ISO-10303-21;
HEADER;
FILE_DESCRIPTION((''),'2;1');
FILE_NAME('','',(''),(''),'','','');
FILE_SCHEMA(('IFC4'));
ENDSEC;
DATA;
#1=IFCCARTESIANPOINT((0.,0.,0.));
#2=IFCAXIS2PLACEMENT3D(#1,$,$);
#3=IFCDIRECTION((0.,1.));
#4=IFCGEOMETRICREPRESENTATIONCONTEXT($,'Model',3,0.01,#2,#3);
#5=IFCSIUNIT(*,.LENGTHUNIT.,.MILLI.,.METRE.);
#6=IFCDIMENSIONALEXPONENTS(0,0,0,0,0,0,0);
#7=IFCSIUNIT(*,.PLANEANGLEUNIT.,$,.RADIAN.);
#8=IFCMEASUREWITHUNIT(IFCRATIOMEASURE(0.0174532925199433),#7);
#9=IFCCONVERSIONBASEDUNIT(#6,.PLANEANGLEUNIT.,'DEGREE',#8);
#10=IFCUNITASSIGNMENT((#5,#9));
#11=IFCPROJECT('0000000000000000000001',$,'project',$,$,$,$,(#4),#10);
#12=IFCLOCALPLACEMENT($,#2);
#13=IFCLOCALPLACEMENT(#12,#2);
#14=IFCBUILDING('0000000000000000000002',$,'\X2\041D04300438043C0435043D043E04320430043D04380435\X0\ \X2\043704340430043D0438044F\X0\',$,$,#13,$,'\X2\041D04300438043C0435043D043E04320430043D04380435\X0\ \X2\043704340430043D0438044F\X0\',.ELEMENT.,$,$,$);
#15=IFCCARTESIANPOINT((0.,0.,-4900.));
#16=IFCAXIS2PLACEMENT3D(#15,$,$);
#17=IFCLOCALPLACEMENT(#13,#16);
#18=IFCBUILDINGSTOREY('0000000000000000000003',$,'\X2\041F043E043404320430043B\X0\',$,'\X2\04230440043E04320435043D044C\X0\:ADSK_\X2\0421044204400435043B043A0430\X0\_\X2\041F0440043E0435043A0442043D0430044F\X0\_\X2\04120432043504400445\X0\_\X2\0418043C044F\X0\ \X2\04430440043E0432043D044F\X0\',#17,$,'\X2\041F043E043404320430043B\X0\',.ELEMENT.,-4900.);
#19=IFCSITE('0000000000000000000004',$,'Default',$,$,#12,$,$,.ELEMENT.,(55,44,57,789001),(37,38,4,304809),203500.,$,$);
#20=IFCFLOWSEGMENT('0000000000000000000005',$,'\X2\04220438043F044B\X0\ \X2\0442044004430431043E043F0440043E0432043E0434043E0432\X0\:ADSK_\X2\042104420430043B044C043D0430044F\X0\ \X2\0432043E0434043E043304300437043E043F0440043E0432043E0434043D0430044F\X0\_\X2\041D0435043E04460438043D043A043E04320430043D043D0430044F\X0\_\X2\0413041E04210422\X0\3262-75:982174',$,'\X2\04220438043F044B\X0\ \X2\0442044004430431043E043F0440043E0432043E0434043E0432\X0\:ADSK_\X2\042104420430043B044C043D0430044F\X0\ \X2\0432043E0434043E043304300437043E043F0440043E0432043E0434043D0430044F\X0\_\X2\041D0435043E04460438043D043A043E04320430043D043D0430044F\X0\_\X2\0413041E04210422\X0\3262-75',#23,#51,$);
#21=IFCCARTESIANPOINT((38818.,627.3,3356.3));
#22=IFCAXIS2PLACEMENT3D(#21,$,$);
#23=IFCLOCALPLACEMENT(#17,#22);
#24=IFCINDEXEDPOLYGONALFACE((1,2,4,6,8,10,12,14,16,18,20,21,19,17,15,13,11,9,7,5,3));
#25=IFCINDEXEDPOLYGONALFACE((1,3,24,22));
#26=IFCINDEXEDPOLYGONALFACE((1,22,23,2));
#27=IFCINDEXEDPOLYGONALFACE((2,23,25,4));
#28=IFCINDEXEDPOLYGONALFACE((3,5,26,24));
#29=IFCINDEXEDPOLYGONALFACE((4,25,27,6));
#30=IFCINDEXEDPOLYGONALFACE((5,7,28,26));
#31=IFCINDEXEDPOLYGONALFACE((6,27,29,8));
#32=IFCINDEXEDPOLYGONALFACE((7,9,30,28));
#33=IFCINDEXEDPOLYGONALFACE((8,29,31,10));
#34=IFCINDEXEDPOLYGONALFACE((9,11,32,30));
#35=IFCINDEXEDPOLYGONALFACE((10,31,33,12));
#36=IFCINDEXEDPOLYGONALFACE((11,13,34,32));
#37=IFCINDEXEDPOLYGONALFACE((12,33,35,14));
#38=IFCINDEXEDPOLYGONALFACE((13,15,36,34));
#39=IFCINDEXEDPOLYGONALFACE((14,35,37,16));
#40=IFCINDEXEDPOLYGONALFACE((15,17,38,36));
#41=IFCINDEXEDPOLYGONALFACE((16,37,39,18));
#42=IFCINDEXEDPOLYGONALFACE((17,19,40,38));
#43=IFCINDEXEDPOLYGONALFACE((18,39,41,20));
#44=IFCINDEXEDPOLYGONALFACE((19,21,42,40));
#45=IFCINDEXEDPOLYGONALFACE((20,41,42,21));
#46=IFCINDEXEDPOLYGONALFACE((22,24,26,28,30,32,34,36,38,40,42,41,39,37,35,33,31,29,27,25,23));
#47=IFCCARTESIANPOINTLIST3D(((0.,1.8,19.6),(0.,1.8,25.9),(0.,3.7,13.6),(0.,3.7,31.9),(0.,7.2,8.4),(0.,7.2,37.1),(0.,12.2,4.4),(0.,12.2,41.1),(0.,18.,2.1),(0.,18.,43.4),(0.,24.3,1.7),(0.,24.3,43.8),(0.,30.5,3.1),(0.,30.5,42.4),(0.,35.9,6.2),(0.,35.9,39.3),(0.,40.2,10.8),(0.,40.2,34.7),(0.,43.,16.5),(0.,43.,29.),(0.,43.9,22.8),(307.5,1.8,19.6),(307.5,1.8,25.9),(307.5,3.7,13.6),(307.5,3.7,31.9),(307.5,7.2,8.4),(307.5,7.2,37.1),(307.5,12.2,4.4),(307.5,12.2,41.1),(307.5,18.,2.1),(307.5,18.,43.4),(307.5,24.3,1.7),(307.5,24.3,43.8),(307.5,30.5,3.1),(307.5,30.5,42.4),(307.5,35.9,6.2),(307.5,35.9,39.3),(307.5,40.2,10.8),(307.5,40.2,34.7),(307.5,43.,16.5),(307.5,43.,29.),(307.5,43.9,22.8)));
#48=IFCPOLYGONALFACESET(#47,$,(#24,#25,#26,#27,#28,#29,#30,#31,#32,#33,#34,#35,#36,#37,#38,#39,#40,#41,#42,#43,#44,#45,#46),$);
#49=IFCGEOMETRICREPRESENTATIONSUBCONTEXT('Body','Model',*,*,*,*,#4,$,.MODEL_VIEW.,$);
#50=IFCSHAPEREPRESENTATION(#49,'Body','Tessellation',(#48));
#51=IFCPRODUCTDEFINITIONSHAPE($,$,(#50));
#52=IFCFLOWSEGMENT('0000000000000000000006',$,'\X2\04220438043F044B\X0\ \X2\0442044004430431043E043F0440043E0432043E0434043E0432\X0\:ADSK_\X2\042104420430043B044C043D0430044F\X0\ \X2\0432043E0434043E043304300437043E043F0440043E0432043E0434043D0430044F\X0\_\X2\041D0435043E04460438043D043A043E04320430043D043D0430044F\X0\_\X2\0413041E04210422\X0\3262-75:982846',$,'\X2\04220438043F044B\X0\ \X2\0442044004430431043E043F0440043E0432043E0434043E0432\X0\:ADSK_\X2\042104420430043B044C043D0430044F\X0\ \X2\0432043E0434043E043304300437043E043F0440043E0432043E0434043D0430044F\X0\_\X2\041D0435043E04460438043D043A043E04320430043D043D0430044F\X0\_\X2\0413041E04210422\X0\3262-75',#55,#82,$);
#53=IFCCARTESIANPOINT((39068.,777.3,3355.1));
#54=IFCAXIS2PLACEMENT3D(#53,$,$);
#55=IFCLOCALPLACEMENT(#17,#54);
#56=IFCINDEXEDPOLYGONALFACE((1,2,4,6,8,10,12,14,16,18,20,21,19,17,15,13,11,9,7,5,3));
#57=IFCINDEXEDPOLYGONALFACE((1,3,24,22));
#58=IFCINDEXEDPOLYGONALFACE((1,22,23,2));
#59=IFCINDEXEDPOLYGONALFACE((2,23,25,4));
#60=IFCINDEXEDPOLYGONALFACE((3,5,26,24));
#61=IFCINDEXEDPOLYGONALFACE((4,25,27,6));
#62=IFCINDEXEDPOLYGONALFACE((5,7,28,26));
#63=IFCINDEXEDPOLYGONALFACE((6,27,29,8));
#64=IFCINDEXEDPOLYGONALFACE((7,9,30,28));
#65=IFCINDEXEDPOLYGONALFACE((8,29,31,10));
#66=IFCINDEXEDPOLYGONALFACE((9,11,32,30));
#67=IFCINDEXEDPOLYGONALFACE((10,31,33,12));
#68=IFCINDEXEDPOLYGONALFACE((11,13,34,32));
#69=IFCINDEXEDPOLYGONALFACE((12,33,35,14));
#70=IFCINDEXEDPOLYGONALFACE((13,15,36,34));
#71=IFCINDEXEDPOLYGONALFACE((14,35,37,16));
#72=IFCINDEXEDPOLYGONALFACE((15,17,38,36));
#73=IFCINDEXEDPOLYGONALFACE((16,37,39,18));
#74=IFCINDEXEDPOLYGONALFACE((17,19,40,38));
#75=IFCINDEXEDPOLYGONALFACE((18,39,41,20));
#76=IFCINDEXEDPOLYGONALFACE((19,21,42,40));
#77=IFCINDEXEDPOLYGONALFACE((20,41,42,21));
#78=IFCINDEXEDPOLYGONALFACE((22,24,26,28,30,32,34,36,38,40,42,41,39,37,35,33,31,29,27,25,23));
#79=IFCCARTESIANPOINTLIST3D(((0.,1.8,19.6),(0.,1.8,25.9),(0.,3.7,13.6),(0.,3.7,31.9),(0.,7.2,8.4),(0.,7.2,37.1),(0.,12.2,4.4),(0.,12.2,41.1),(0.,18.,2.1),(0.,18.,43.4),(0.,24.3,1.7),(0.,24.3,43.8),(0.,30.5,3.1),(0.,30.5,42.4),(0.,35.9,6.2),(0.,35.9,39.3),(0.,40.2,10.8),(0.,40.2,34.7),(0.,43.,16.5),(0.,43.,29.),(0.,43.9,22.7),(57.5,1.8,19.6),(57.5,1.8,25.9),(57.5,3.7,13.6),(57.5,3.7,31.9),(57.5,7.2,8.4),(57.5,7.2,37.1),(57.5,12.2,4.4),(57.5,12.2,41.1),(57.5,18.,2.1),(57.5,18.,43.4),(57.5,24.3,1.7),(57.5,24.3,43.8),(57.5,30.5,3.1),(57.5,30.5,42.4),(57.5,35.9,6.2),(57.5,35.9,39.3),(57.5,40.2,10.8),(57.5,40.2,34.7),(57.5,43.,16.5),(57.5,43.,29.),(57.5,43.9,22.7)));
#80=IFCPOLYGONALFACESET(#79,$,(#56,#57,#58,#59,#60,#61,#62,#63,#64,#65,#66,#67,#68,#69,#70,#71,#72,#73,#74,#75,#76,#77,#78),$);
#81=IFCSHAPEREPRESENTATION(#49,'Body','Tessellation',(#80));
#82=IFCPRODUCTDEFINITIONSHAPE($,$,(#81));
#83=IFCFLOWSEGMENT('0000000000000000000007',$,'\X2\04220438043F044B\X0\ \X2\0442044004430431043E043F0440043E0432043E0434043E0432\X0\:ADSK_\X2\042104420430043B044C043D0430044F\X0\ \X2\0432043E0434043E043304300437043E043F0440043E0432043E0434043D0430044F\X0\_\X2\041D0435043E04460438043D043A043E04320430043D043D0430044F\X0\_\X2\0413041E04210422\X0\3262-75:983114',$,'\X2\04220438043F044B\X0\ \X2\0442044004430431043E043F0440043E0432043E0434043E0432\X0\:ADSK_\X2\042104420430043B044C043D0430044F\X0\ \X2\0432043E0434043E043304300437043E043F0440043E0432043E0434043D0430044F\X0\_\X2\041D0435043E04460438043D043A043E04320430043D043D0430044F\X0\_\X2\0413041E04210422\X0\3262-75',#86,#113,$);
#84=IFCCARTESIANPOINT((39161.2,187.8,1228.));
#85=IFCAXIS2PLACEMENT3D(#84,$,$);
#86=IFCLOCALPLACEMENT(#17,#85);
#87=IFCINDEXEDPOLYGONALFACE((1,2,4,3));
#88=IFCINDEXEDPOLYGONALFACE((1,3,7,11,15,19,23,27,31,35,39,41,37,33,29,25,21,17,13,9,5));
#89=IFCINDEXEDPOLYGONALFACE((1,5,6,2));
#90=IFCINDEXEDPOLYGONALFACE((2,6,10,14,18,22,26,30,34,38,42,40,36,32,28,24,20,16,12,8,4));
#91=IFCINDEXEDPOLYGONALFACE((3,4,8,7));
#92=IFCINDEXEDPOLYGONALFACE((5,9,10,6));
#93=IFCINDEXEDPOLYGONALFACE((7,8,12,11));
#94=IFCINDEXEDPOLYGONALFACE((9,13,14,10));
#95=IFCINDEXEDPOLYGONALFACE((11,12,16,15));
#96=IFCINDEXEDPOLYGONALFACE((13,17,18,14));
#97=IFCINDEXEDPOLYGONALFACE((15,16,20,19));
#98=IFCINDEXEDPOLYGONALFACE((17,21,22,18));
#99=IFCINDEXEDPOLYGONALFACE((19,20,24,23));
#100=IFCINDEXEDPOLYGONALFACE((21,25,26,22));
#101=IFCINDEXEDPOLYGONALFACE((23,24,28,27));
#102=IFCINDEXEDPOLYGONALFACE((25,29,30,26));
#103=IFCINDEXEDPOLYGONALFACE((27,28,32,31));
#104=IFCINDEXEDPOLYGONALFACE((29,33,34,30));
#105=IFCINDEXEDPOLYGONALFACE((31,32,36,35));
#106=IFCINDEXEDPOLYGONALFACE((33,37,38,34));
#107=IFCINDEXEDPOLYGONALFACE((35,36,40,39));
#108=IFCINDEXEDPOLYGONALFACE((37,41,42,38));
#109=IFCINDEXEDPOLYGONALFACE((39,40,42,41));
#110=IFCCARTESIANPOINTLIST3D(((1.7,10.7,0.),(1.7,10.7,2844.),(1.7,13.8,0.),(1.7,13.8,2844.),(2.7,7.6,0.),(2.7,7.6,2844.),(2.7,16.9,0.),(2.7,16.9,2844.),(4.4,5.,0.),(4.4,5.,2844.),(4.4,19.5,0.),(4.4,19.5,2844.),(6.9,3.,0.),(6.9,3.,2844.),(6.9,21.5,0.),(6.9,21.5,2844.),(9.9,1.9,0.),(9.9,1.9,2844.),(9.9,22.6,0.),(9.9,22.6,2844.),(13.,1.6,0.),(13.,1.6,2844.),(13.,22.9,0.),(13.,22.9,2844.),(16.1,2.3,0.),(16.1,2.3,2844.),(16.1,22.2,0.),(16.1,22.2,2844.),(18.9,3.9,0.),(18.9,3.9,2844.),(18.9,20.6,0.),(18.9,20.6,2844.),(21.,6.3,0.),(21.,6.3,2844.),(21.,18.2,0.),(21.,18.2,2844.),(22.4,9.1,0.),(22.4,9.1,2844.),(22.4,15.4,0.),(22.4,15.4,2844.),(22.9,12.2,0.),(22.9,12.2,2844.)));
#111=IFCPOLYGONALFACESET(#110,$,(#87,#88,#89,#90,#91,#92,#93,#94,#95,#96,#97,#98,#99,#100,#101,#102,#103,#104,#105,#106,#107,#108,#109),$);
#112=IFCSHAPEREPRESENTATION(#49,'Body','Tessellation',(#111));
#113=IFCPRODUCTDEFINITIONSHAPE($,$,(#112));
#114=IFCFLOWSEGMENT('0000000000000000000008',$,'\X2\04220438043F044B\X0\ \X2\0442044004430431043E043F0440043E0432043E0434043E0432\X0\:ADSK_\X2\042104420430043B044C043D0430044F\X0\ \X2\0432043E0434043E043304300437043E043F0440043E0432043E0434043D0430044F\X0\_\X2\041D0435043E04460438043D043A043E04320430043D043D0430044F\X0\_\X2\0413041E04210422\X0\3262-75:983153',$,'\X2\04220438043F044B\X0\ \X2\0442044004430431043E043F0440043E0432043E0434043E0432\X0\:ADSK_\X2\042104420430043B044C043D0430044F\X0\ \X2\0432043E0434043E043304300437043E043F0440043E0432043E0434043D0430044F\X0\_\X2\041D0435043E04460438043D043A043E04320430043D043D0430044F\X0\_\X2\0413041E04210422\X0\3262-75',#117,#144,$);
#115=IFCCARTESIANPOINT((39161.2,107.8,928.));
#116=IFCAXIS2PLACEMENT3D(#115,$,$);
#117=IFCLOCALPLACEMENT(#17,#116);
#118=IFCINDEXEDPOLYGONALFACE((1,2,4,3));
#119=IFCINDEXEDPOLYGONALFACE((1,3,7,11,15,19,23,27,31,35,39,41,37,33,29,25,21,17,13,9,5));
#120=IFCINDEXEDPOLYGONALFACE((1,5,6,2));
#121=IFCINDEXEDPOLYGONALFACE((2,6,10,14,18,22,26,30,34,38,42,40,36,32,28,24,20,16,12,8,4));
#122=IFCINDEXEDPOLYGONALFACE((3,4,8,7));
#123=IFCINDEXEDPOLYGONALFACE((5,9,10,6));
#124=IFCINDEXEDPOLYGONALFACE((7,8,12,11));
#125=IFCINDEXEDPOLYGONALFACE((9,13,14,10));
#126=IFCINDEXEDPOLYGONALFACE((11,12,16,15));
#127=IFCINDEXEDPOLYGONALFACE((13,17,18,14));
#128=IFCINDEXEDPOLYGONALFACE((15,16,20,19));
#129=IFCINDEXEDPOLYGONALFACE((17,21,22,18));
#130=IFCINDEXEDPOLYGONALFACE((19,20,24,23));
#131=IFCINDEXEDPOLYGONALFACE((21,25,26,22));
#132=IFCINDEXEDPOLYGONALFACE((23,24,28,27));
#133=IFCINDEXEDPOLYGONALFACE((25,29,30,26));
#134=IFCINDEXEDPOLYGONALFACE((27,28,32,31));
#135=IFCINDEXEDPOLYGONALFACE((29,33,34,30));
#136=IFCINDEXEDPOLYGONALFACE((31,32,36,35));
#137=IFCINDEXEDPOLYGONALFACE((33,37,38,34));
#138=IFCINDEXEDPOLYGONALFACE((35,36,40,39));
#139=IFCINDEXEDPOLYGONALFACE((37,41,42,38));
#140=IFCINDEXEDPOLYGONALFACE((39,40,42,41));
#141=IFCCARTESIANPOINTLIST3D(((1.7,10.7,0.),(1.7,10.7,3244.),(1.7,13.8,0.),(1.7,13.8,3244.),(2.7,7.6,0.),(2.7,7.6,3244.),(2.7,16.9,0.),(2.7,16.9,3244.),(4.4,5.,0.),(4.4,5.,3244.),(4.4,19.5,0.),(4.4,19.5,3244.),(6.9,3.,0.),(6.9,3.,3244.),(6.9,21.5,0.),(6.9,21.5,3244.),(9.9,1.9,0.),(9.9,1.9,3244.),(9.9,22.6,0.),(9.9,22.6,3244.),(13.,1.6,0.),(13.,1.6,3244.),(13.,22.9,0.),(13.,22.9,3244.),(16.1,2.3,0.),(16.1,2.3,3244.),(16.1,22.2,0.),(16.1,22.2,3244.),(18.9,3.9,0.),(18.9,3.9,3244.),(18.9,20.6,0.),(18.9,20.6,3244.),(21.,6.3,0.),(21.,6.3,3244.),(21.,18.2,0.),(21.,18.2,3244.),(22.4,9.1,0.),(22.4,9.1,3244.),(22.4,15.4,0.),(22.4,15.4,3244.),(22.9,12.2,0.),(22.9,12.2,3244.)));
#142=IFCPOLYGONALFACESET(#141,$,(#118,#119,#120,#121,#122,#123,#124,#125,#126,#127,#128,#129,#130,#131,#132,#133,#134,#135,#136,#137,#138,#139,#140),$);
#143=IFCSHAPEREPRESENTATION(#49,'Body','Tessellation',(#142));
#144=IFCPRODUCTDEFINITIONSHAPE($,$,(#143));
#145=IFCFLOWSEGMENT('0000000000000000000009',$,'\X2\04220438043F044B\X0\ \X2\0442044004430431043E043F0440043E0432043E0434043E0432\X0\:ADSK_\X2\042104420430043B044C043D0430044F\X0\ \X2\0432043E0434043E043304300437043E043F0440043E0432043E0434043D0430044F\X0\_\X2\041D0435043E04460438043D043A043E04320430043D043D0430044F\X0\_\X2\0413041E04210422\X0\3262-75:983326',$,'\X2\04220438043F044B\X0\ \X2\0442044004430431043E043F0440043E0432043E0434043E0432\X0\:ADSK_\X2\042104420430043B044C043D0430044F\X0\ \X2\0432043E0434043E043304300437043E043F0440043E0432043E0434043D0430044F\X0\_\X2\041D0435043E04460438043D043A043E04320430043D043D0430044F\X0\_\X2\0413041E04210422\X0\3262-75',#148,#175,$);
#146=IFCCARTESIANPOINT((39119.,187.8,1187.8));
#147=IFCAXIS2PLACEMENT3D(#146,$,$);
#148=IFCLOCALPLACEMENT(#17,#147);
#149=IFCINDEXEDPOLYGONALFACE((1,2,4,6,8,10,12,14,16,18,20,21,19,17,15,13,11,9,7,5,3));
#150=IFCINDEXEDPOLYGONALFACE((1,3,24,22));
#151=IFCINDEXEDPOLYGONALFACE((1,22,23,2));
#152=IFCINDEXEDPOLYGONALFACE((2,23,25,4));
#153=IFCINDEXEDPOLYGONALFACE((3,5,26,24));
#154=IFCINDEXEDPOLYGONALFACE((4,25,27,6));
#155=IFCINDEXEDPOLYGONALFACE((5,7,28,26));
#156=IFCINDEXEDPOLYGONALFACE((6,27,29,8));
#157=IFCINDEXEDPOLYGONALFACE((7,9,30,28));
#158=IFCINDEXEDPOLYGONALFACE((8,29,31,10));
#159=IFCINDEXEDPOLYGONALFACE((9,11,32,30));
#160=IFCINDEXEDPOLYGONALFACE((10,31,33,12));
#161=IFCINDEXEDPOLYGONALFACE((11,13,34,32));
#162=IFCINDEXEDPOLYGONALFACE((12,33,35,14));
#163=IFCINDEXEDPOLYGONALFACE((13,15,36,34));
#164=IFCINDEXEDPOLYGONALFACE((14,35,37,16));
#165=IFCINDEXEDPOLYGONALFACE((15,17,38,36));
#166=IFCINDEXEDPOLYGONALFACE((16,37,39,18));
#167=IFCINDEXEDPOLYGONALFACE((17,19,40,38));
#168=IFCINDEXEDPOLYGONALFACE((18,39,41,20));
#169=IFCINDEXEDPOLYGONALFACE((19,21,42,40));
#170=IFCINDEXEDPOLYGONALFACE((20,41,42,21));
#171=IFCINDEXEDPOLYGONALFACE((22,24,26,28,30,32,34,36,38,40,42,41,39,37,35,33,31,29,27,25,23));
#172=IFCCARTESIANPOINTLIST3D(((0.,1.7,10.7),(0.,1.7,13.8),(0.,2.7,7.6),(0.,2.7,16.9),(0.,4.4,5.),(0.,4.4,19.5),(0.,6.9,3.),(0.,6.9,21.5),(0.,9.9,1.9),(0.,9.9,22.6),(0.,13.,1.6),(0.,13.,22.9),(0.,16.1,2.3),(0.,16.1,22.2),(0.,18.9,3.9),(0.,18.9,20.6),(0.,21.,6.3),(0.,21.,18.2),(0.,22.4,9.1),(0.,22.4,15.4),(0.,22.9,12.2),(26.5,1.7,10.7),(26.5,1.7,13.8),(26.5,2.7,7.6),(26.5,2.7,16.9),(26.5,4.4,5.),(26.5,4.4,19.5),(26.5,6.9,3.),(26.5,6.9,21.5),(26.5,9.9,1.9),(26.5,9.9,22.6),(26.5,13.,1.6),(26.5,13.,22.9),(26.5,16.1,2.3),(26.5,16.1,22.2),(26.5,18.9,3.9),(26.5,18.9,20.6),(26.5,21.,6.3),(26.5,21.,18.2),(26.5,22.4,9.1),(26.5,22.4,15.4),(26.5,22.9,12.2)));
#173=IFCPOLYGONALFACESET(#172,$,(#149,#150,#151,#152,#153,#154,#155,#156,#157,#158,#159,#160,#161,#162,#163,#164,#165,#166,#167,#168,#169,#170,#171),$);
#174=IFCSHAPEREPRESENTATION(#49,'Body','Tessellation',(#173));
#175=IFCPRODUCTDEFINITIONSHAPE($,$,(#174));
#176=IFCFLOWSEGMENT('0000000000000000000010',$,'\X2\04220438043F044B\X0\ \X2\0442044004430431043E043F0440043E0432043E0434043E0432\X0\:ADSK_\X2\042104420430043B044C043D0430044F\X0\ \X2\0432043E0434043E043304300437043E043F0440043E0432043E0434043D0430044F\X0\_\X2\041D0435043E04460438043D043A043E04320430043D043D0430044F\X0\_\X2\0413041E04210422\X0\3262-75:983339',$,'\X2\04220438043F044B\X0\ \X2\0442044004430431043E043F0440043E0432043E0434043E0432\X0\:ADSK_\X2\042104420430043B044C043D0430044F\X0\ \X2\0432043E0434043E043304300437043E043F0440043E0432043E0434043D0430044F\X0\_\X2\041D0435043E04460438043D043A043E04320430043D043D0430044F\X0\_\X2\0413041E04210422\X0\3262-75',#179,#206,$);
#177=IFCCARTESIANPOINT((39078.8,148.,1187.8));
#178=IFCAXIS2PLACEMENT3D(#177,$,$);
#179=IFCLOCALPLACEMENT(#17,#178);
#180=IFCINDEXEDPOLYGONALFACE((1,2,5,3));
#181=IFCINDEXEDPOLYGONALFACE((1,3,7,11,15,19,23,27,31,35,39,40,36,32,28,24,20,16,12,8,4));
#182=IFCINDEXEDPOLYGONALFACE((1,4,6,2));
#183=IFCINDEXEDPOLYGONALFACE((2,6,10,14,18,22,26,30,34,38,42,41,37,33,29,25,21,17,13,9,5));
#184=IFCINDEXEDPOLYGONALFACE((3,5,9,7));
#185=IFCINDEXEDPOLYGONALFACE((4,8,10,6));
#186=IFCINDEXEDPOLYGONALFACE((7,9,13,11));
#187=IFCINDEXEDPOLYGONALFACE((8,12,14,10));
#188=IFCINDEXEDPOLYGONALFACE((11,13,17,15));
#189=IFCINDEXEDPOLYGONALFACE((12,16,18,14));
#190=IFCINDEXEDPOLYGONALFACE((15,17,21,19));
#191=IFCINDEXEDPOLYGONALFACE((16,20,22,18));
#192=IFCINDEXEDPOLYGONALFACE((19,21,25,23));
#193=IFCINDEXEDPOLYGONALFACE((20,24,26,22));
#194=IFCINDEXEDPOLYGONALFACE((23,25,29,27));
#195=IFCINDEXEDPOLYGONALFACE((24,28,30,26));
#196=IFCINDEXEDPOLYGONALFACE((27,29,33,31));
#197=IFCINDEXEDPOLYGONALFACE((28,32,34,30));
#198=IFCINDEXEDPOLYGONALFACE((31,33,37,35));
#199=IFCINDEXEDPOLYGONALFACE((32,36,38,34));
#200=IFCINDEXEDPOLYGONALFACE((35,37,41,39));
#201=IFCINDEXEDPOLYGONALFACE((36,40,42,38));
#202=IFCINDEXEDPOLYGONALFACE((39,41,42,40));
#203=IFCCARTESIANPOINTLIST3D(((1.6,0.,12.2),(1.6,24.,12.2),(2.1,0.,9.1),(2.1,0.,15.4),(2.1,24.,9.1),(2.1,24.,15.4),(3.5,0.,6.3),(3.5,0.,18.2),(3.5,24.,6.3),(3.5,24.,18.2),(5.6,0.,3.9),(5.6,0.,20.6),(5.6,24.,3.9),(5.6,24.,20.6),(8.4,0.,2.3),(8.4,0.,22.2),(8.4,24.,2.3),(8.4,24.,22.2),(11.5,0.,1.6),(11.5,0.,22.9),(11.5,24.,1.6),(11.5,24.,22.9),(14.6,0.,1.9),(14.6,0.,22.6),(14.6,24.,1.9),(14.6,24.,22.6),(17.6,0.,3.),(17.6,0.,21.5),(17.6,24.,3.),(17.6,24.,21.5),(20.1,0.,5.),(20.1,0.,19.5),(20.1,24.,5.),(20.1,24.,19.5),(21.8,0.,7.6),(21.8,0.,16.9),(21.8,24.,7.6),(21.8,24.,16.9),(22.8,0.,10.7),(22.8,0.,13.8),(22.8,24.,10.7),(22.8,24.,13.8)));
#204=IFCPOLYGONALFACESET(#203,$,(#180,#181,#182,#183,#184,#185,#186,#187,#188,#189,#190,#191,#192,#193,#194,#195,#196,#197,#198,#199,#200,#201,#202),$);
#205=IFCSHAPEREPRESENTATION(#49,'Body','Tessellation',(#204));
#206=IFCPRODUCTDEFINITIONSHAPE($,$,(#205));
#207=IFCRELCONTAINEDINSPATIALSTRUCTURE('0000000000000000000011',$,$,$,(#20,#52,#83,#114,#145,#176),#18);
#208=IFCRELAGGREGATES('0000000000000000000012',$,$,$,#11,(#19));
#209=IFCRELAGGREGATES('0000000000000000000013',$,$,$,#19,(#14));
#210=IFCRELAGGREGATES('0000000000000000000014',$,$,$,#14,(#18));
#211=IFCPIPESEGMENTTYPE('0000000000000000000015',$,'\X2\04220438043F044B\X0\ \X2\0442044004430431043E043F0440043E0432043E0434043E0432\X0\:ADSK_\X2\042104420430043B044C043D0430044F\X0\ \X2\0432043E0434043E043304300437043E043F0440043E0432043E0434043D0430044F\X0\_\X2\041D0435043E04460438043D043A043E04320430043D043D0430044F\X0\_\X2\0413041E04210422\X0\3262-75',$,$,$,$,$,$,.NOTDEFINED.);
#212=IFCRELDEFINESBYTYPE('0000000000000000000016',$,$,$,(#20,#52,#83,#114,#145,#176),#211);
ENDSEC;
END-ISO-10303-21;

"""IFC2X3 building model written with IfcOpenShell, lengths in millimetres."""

from ifc_helpers import new_model, entity, si_unit, converted_unit, direction, frame, origin, origin_2d_with_axis, place, context, subcontext, project, spatial, circle, extrude, type_object, element, save


model = new_model("IFC2X3")

# Units and contexts
model_context = context("Model", 3, precision=0.01, world=origin(), true_north=direction((0.0, 1.0)))
body_context = subcontext(model_context, "Body", "Model", "MODEL_VIEW")
ifc_project = project(units=[si_unit("LENGTHUNIT", "METRE", prefix="MILLI"), converted_unit("PLANEANGLEUNIT", "DEGREE", entity("IfcRatioMeasure", 0.0174532925199433), si_unit("PLANEANGLEUNIT", "RADIAN"), dimensions=[0, 0, 0, 0, 0, 0, 0])], contexts=[model_context])

# Site, building, storey
site_placement = place(None, origin())
site = spatial("IfcSite", under=ifc_project, at=site_placement, Name="Default", CompositionType="ELEMENT", RefLatitude=(55, 44, 57, 789001), RefLongitude=(37, 38, 4, 304809), RefElevation=203500.0)
building_placement = place(site_placement, origin())
building = spatial("IfcBuilding", under=site, at=building_placement, Name="Наименование здания", LongName="Наименование здания", CompositionType="ELEMENT")
storey_placement = place(building_placement, frame((0.0, 0.0, -4900.0)))
storey = spatial("IfcBuildingStorey", under=building, at=storey_placement, Name="Подвал", ObjectType="Уровень:ADSK_Стрелка_Проектная_Вверх_Имя уровня", LongName="Подвал", CompositionType="ELEMENT", Elevation=-4900.0)

# Flow segments
pipe_segment_type = type_object("IfcPipeSegmentType", Name="Типы трубопроводов:ADSK_Стальная водогазопроводная_Неоцинкованная_ГОСТ3262-75", PredefinedType="NOTDEFINED")
flow_segment_1_placement = place(storey_placement, frame((38818.0, 627.3, 3356.3)))
element("IfcFlowSegment", 1, at=flow_segment_1_placement, inside=storey, type_object=pipe_segment_type, Name="Типы трубопроводов:ADSK_Стальная водогазопроводная_Неоцинкованная_ГОСТ3262-75:982174", ObjectType="Типы трубопроводов:ADSK_Стальная водогазопроводная_Неоцинкованная_ГОСТ3262-75", context=body_context, shape_type="SweptSolid", body=[
    extrude(circle(Radius=21.1, at=origin_2d_with_axis()), frame((0.0, 22.8, 22.8), z_axis=(1.0, 0.0, 0.0), x_axis=(0.0, 1.0, 0.0)), (0.0, 0.0, 1.0), 307.5),
])
flow_segment_2_placement = place(storey_placement, frame((39068.0, 777.3, 3355.1)))
element("IfcFlowSegment", 2, at=flow_segment_2_placement, inside=storey, type_object=pipe_segment_type, Name="Типы трубопроводов:ADSK_Стальная водогазопроводная_Неоцинкованная_ГОСТ3262-75:982846", ObjectType="Типы трубопроводов:ADSK_Стальная водогазопроводная_Неоцинкованная_ГОСТ3262-75", context=body_context, shape_type="SweptSolid", body=[
    extrude(circle(Radius=21.1, at=origin_2d_with_axis()), frame((0.0, 22.8, 22.8), z_axis=(1.0, 0.0, 0.0), x_axis=(0.0, 1.0, 0.0)), (0.0, 0.0, 1.0), 57.5),
])
flow_segment_3_placement = place(storey_placement, frame((39161.2, 187.8, 1228.0)))
element("IfcFlowSegment", 3, at=flow_segment_3_placement, inside=storey, type_object=pipe_segment_type, Name="Типы трубопроводов:ADSK_Стальная водогазопроводная_Неоцинкованная_ГОСТ3262-75:983114", ObjectType="Типы трубопроводов:ADSK_Стальная водогазопроводная_Неоцинкованная_ГОСТ3262-75", context=body_context, shape_type="SweptSolid", body=[
    extrude(circle(Radius=10.7, at=origin_2d_with_axis()), frame((12.2, 12.2, 0.0)), (0.0, 0.0, 1.0), 2844.0),
])
flow_segment_4_placement = place(storey_placement, frame((39161.2, 107.8, 928.0)))
element("IfcFlowSegment", 4, at=flow_segment_4_placement, inside=storey, type_object=pipe_segment_type, Name="Типы трубопроводов:ADSK_Стальная водогазопроводная_Неоцинкованная_ГОСТ3262-75:983153", ObjectType="Типы трубопроводов:ADSK_Стальная водогазопроводная_Неоцинкованная_ГОСТ3262-75", context=body_context, shape_type="SweptSolid", body=[
    extrude(circle(Radius=10.7, at=origin_2d_with_axis()), frame((12.2, 12.2, 0.0)), (0.0, 0.0, 1.0), 3244.0),
])
flow_segment_5_placement = place(storey_placement, frame((39119.0, 187.8, 1187.8)))
element("IfcFlowSegment", 5, at=flow_segment_5_placement, inside=storey, type_object=pipe_segment_type, Name="Типы трубопроводов:ADSK_Стальная водогазопроводная_Неоцинкованная_ГОСТ3262-75:983326", ObjectType="Типы трубопроводов:ADSK_Стальная водогазопроводная_Неоцинкованная_ГОСТ3262-75", context=body_context, shape_type="SweptSolid", body=[
    extrude(circle(Radius=10.7, at=origin_2d_with_axis()), frame((0.0, 12.2, 12.2), z_axis=(1.0, 0.0, 0.0), x_axis=(0.0, 1.0, 0.0)), (0.0, 0.0, 1.0), 26.5),
])
flow_segment_6_placement = place(storey_placement, frame((39078.8, 148.0, 1187.8)))
element("IfcFlowSegment", 6, at=flow_segment_6_placement, inside=storey, type_object=pipe_segment_type, Name="Типы трубопроводов:ADSK_Стальная водогазопроводная_Неоцинкованная_ГОСТ3262-75:983339", ObjectType="Типы трубопроводов:ADSK_Стальная водогазопроводная_Неоцинкованная_ГОСТ3262-75", context=body_context, shape_type="SweptSolid", body=[
    extrude(circle(Radius=10.7, at=origin_2d_with_axis()), frame((12.2, 0.0, 12.2), z_axis=(0.0, 1.0, 0.0), x_axis=(-1.0, 0.0, 0.0)), (0.0, 0.0, 1.0), 24.0),
])

save(model, "model.ifc")
